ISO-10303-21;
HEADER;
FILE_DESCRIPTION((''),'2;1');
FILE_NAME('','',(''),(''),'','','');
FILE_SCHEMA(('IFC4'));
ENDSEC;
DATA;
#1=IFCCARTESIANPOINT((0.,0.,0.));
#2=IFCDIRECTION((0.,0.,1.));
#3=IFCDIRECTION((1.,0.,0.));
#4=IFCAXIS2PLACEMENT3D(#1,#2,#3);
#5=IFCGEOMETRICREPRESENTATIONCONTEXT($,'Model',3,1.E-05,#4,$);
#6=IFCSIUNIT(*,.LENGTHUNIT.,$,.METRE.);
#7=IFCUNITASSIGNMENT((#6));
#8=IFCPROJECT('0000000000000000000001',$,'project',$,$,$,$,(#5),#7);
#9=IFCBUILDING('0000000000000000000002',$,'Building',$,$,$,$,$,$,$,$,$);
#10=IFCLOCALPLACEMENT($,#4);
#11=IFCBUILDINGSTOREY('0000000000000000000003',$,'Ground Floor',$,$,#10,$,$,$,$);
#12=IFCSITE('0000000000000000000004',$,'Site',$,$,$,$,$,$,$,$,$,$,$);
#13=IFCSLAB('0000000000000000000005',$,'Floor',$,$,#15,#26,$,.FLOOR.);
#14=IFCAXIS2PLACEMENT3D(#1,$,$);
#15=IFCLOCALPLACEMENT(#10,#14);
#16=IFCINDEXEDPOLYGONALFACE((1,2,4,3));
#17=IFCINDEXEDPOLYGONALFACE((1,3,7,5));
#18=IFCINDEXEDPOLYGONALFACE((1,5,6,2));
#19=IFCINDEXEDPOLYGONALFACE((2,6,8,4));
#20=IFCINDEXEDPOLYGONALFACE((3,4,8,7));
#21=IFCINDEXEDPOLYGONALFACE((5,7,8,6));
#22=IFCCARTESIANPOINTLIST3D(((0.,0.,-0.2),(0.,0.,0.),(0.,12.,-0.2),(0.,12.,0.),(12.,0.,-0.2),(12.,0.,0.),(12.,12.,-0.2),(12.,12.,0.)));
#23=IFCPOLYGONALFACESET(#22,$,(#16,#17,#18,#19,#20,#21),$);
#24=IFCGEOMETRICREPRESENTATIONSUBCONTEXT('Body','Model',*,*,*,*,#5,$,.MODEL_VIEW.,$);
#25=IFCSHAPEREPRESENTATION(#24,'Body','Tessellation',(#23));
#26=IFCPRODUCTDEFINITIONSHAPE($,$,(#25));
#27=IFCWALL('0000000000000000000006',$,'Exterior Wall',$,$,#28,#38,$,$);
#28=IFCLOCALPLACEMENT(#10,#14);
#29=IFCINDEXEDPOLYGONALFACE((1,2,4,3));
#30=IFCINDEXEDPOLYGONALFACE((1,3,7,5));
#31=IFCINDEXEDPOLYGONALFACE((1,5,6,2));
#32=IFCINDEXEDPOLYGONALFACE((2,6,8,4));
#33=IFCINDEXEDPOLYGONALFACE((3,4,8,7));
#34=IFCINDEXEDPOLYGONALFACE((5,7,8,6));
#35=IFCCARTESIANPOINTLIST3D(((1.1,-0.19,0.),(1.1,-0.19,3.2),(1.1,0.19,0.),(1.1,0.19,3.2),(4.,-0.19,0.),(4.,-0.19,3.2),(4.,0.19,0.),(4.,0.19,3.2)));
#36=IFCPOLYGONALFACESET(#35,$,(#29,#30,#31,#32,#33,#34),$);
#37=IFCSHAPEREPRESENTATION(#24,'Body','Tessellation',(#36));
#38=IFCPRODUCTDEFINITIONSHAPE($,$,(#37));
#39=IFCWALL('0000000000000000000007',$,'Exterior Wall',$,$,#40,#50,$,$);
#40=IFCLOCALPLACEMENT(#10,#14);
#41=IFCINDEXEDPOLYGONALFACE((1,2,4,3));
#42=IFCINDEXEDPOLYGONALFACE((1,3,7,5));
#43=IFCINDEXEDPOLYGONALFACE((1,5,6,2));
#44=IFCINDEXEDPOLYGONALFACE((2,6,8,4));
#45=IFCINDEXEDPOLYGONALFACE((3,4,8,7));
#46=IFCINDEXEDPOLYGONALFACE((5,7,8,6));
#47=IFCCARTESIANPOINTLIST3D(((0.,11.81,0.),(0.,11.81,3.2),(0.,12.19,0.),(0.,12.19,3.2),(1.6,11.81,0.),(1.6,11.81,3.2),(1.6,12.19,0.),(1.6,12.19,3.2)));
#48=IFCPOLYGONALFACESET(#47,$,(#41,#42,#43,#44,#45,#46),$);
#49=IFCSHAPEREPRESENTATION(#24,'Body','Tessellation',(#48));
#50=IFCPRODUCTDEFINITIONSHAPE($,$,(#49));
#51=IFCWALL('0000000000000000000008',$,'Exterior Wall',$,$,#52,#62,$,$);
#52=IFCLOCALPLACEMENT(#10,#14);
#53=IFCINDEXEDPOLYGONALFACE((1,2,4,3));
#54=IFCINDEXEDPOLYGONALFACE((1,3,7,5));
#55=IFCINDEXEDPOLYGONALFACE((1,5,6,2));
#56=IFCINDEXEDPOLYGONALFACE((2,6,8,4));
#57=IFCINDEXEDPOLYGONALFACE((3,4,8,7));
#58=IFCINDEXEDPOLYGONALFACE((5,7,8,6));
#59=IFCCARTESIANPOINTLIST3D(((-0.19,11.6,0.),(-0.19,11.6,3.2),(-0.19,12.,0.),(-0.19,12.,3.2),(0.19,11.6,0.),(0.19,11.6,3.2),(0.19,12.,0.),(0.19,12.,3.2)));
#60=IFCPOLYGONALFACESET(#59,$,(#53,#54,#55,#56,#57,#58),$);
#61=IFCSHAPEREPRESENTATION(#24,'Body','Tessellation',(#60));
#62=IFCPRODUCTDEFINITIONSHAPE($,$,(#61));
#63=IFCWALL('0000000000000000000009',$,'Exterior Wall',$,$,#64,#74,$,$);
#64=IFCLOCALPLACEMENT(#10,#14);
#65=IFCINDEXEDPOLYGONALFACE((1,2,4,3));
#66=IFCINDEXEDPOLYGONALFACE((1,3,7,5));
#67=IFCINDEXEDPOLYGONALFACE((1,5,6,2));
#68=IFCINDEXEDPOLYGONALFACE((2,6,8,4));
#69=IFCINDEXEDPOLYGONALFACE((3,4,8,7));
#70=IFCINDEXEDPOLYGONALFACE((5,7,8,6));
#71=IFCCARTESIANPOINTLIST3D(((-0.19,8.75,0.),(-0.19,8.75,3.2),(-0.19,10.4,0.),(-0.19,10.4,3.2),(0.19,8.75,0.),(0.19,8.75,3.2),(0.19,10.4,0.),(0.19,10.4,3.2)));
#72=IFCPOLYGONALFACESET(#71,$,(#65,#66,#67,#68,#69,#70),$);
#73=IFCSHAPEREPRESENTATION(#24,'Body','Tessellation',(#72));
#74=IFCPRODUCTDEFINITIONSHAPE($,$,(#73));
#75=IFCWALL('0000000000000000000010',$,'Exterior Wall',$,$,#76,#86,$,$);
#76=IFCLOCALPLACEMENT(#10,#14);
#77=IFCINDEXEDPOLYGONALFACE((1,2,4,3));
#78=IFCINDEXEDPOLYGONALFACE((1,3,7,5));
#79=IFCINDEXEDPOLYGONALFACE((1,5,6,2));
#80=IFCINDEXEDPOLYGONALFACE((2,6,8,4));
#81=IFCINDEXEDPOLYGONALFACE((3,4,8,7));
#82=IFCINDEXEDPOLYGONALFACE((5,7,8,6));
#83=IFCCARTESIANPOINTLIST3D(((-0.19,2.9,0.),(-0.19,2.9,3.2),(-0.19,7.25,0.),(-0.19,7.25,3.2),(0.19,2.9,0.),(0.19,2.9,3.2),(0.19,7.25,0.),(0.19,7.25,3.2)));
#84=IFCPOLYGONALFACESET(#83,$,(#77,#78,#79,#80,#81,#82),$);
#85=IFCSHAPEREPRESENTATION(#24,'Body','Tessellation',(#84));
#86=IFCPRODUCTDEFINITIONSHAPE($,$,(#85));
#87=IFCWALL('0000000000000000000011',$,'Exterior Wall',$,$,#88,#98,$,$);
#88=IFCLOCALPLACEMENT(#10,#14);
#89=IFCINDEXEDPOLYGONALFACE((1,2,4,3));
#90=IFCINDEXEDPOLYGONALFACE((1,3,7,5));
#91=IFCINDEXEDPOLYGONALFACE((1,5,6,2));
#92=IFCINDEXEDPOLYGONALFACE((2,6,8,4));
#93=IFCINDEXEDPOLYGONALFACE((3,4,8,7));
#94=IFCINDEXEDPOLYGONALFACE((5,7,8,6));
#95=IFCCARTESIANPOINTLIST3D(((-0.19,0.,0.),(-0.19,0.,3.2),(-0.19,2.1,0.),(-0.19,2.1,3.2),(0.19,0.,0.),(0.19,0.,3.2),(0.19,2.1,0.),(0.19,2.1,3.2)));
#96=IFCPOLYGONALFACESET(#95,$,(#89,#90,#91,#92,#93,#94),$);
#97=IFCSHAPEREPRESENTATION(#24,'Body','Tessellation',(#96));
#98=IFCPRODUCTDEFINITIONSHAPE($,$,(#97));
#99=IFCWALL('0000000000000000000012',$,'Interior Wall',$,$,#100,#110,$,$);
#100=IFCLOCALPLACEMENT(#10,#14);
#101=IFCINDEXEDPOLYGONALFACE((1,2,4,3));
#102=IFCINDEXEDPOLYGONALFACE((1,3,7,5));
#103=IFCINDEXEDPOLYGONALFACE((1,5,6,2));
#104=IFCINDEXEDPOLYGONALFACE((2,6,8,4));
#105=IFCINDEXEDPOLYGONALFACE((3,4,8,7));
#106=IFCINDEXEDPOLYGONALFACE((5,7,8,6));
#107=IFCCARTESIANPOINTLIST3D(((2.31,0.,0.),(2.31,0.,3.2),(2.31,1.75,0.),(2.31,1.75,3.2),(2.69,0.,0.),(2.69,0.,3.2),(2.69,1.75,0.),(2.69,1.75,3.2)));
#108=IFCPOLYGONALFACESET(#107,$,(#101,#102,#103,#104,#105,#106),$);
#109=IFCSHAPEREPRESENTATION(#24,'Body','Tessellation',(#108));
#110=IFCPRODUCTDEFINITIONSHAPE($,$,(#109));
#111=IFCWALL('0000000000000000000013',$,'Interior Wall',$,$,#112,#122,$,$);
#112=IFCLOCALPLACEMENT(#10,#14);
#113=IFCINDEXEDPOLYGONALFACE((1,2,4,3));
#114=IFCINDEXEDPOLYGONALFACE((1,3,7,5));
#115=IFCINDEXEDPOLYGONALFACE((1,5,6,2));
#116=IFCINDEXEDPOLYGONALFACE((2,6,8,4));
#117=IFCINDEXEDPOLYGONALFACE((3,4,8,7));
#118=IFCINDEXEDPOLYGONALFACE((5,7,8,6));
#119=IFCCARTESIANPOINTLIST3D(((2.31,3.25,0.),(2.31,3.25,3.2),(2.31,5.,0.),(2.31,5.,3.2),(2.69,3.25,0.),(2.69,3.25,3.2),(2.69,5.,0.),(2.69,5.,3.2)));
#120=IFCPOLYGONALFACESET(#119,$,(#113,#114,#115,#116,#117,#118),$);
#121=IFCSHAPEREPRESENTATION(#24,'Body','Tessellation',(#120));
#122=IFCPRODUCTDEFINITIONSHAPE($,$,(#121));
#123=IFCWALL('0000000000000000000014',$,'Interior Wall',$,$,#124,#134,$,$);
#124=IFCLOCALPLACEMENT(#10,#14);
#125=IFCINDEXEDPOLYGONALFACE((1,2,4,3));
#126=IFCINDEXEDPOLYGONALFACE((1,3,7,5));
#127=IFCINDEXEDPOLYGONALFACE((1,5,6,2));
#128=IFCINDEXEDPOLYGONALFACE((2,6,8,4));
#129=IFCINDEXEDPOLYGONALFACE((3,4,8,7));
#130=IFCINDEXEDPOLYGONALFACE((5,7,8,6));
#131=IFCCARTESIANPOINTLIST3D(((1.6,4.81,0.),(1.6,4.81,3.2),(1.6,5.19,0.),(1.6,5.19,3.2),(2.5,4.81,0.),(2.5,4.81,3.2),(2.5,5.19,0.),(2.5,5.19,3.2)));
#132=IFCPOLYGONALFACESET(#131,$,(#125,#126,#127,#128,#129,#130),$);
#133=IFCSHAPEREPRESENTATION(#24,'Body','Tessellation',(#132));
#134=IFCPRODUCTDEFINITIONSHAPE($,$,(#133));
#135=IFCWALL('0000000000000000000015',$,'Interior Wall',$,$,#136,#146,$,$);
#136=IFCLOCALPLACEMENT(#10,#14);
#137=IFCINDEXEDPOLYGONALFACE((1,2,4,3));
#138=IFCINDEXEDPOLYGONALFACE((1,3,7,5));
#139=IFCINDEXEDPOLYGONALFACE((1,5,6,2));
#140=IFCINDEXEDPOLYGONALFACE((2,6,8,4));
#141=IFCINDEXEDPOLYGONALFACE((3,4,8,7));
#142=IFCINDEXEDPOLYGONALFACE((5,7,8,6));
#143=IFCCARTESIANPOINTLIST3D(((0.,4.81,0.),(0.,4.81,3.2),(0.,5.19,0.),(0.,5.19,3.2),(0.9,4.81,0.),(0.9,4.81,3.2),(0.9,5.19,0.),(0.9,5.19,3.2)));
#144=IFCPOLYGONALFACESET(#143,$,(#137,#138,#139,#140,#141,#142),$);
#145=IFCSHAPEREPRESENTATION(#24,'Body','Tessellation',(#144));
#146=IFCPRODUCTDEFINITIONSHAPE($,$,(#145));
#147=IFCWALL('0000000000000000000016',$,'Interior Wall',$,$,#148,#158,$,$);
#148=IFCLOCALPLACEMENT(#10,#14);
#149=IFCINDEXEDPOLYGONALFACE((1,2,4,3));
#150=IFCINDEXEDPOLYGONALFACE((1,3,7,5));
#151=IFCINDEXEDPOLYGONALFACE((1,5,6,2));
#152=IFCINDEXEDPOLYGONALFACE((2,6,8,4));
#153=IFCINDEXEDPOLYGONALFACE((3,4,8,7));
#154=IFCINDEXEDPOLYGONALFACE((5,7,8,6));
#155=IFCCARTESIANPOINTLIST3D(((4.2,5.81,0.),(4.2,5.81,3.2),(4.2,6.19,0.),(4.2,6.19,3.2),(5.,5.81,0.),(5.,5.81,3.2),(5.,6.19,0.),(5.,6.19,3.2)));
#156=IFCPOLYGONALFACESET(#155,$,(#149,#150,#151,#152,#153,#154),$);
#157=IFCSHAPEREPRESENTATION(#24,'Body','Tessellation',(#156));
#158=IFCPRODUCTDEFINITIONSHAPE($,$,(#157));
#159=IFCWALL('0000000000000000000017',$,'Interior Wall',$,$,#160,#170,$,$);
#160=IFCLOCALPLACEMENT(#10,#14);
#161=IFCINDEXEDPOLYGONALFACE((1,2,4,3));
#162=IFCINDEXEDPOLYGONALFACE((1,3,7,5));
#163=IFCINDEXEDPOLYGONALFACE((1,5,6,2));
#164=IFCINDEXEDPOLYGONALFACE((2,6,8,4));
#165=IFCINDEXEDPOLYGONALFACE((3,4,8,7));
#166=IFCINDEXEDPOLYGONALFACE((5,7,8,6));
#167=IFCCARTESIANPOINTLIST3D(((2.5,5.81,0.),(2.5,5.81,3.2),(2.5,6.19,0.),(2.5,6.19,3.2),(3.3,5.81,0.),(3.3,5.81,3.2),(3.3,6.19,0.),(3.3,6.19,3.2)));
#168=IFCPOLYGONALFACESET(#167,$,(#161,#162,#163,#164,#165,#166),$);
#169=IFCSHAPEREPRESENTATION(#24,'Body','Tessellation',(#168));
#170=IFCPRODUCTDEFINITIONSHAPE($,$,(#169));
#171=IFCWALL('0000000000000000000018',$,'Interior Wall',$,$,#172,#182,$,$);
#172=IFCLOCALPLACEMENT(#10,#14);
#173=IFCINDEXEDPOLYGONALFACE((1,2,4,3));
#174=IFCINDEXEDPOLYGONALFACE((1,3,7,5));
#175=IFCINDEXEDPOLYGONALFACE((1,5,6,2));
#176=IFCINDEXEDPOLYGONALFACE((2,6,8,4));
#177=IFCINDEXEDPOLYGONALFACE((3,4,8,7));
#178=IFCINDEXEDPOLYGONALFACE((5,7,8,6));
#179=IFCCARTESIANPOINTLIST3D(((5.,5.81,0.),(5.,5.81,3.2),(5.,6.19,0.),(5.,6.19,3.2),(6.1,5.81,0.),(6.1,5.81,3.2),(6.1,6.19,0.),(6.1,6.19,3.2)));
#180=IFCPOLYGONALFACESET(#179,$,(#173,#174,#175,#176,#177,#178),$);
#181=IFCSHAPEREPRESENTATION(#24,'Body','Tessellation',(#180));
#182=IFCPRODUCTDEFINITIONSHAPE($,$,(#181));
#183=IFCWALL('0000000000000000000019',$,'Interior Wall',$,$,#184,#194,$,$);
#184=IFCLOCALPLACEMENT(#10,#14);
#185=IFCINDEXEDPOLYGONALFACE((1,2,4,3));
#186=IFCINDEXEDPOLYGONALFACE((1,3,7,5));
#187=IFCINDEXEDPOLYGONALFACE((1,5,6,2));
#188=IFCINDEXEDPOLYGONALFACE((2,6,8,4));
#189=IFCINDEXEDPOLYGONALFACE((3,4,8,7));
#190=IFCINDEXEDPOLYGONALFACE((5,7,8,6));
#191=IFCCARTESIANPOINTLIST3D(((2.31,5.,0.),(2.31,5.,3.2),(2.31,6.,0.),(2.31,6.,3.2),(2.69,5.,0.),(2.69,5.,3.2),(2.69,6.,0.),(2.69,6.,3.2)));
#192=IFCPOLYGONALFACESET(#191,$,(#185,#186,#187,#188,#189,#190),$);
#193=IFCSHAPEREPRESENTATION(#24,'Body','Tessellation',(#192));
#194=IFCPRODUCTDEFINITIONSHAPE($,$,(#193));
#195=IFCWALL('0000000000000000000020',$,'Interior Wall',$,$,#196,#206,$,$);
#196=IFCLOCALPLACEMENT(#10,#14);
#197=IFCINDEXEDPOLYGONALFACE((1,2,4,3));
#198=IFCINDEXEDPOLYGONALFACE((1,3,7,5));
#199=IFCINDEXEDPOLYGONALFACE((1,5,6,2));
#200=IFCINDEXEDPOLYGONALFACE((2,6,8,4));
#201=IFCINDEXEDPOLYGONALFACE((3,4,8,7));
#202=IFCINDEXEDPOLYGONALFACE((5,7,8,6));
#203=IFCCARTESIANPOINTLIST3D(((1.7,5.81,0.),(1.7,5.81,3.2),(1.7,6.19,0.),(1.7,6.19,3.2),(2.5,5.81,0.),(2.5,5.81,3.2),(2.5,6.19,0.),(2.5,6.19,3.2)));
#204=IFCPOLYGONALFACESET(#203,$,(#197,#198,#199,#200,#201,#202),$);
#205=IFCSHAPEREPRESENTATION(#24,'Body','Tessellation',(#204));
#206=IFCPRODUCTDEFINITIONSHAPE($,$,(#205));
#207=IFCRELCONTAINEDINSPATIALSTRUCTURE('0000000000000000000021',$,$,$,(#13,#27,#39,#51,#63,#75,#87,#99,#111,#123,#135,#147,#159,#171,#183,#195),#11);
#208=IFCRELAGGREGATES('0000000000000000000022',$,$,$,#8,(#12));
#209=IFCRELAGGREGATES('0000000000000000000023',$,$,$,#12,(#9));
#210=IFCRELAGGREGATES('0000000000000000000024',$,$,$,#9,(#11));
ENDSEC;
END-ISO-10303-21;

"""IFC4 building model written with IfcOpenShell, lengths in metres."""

from ifc_helpers import new_model, si_unit, frame, origin_with_axes, place, context, subcontext, project, spatial, indexed_curve, outline, extrude, element, save


model = new_model("IFC4")

# Units and contexts
model_context = context("Model", 3, precision=1e-05, world=origin_with_axes())
body_context = subcontext(model_context, "Body", "Model", "MODEL_VIEW")
ifc_project = project(units=[si_unit("LENGTHUNIT", "METRE")], contexts=[model_context])

# Site, building, storey
site = spatial("IfcSite", under=ifc_project, Name="Site")
building = spatial("IfcBuilding", under=site, Name="Building")
storey_placement = place(None, origin_with_axes())
storey = spatial("IfcBuildingStorey", under=building, at=storey_placement, Name="Ground Floor")

# Slab
slab_placement = place(storey_placement, frame((0.0, 0.0, -0.2), z_axis=(0.0, 0.0, 1.0), x_axis=(1.0, 0.0, 0.0)))
element("IfcSlab", 1, at=slab_placement, inside=storey, Name="Floor", PredefinedType="FLOOR", context=body_context, shape_type="SweptSolid", body=[
    extrude(outline(indexed_curve([(0.0, 0.0), (12.0, 0.0), (12.0, 12.0), (0.0, 12.0)])), None, (0.0, 0.0, 1.0), 0.2),
])

# Walls
wall_1_placement = place(storey_placement, frame((1.1, 0.0, 0.0), z_axis=(0.0, 0.0, 1.0), x_axis=(1.0, 0.0, 0.0)))
element("IfcWall", 2, at=wall_1_placement, inside=storey, Name="Exterior Wall", context=body_context, shape_type="SweptSolid", body=[
    extrude(outline(indexed_curve([(0.0, 0.0), (0.0, 0.38), (2.9, 0.38), (2.9, 0.0), (0.0, 0.0)], self_intersect=False)), frame((0.0, -0.19, 0.0), z_axis=(0.0, 0.0, 1.0), x_axis=(1.0, 0.0, 0.0)), (0.0, 0.0, 1.0), 3.2),
])
wall_2_placement = place(storey_placement, frame((1.6, 12.0, 0.0), z_axis=(0.0, 0.0, 1.0), x_axis=(-1.0, 0.0, 0.0)))
element("IfcWall", 3, at=wall_2_placement, inside=storey, Name="Exterior Wall", context=body_context, shape_type="SweptSolid", body=[
    extrude(outline(indexed_curve([(0.0, 0.0), (0.0, 0.38), (1.6, 0.38), (1.6, 0.0), (0.0, 0.0)], self_intersect=False)), frame((0.0, -0.19, 0.0), z_axis=(0.0, 0.0, 1.0), x_axis=(1.0, 0.0, 0.0)), (0.0, 0.0, 1.0), 3.2),
])
wall_3_placement = place(storey_placement, frame((0.0, 12.0, 0.0), z_axis=(0.0, 0.0, 1.0), x_axis=(0.0, -1.0, 0.0)))
element("IfcWall", 4, at=wall_3_placement, inside=storey, Name="Exterior Wall", context=body_context, shape_type="SweptSolid", body=[
    extrude(outline(indexed_curve([(0.0, 0.0), (0.0, 0.38), (0.4, 0.38), (0.4, 0.0), (0.0, 0.0)], self_intersect=False)), frame((0.0, -0.19, 0.0), z_axis=(0.0, 0.0, 1.0), x_axis=(1.0, 0.0, 0.0)), (0.0, 0.0, 1.0), 3.2),
])
wall_4_placement = place(storey_placement, frame((0.0, 10.4, 0.0), z_axis=(0.0, 0.0, 1.0), x_axis=(0.0, -1.0, 0.0)))
element("IfcWall", 5, at=wall_4_placement, inside=storey, Name="Exterior Wall", context=body_context, shape_type="SweptSolid", body=[
    extrude(outline(indexed_curve([(0.0, 0.0), (0.0, 0.38), (1.65, 0.38), (1.65, 0.0), (0.0, 0.0)], self_intersect=False)), frame((0.0, -0.19, 0.0), z_axis=(0.0, 0.0, 1.0), x_axis=(1.0, 0.0, 0.0)), (0.0, 0.0, 1.0), 3.2),
])
wall_5_placement = place(storey_placement, frame((0.0, 7.25, 0.0), z_axis=(0.0, 0.0, 1.0), x_axis=(0.0, -1.0, 0.0)))
element("IfcWall", 6, at=wall_5_placement, inside=storey, Name="Exterior Wall", context=body_context, shape_type="SweptSolid", body=[
    extrude(outline(indexed_curve([(0.0, 0.0), (0.0, 0.38), (4.35, 0.38), (4.35, 0.0), (0.0, 0.0)], self_intersect=False)), frame((0.0, -0.19, 0.0), z_axis=(0.0, 0.0, 1.0), x_axis=(1.0, 0.0, 0.0)), (0.0, 0.0, 1.0), 3.2),
])
wall_6_placement = place(storey_placement, frame((0.0, 2.1, 0.0), z_axis=(0.0, 0.0, 1.0), x_axis=(0.0, -1.0, 0.0)))
element("IfcWall", 7, at=wall_6_placement, inside=storey, Name="Exterior Wall", context=body_context, shape_type="SweptSolid", body=[
    extrude(outline(indexed_curve([(0.0, 0.0), (0.0, 0.38), (2.1, 0.38), (2.1, 0.0), (0.0, 0.0)], self_intersect=False)), frame((0.0, -0.19, 0.0), z_axis=(0.0, 0.0, 1.0), x_axis=(1.0, 0.0, 0.0)), (0.0, 0.0, 1.0), 3.2),
])
for number, where, z_axis, x_axis, name in (
    (8, (2.5, 0.0, 0.0), (0.0, 0.0, 1.0), (0.0, 1.0, 0.0), "Interior Wall"),
    (9, (2.5, 3.25, 0.0), (0.0, 0.0, 1.0), (0.0, 1.0, 0.0), "Interior Wall"),
):
    element("IfcWall", number, at=place(storey_placement, frame(where, z_axis=z_axis, x_axis=x_axis)), inside=storey, Name=name, context=body_context, shape_type="SweptSolid", body=[
        extrude(outline(indexed_curve([(0.0, 0.0), (0.0, 0.38), (1.75, 0.38), (1.75, 0.0), (0.0, 0.0)], self_intersect=False)), frame((0.0, -0.19, 0.0), z_axis=(0.0, 0.0, 1.0), x_axis=(1.0, 0.0, 0.0)), (0.0, 0.0, 1.0), 3.2),
    ])
for number, where, z_axis, x_axis, name in (
    (10, (2.5, 5.0, 0.0), (0.0, 0.0, 1.0), (-1.0, 0.0, 0.0), "Interior Wall"),
    (11, (0.9, 5.0, 0.0), (0.0, 0.0, 1.0), (-1.0, 0.0, 0.0), "Interior Wall"),
):
    element("IfcWall", number, at=place(storey_placement, frame(where, z_axis=z_axis, x_axis=x_axis)), inside=storey, Name=name, context=body_context, shape_type="SweptSolid", body=[
        extrude(outline(indexed_curve([(0.0, 0.0), (0.0, 0.38), (0.9, 0.38), (0.9, 0.0), (0.0, 0.0)], self_intersect=False)), frame((0.0, -0.19, 0.0), z_axis=(0.0, 0.0, 1.0), x_axis=(1.0, 0.0, 0.0)), (0.0, 0.0, 1.0), 3.2),
    ])
for number, where, z_axis, x_axis, name in (
    (12, (5.0, 6.0, 0.0), (0.0, 0.0, 1.0), (-1.0, 0.0, 0.0), "Interior Wall"),
    (13, (3.3, 6.0, 0.0), (0.0, 0.0, 1.0), (-1.0, 0.0, 0.0), "Interior Wall"),
):
    element("IfcWall", number, at=place(storey_placement, frame(where, z_axis=z_axis, x_axis=x_axis)), inside=storey, Name=name, context=body_context, shape_type="SweptSolid", body=[
        extrude(outline(indexed_curve([(0.0, 0.0), (0.0, 0.38), (0.8, 0.38), (0.8, 0.0), (0.0, 0.0)], self_intersect=False)), frame((0.0, -0.19, 0.0), z_axis=(0.0, 0.0, 1.0), x_axis=(1.0, 0.0, 0.0)), (0.0, 0.0, 1.0), 3.2),
    ])
wall_7_placement = place(storey_placement, frame((6.1, 6.0, 0.0), z_axis=(0.0, 0.0, 1.0), x_axis=(-1.0, 0.0, 0.0)))
element("IfcWall", 14, at=wall_7_placement, inside=storey, Name="Interior Wall", context=body_context, shape_type="SweptSolid", body=[
    extrude(outline(indexed_curve([(0.0, 0.0), (0.0, 0.38), (1.1, 0.38), (1.1, 0.0), (0.0, 0.0)], self_intersect=False)), frame((0.0, -0.19, 0.0), z_axis=(0.0, 0.0, 1.0), x_axis=(1.0, 0.0, 0.0)), (0.0, 0.0, 1.0), 3.2),
])
wall_8_placement = place(storey_placement, frame((2.5, 6.0, 0.0), z_axis=(0.0, 0.0, 1.0), x_axis=(0.0, -1.0, 0.0)))
element("IfcWall", 15, at=wall_8_placement, inside=storey, Name="Interior Wall", context=body_context, shape_type="SweptSolid", body=[
    extrude(outline(indexed_curve([(0.0, 0.0), (0.0, 0.38), (1.0, 0.38), (1.0, 0.0), (0.0, 0.0)], self_intersect=False)), frame((0.0, -0.19, 0.0), z_axis=(0.0, 0.0, 1.0), x_axis=(1.0, 0.0, 0.0)), (0.0, 0.0, 1.0), 3.2),
])
for number, where, z_axis, x_axis, name in (
    (16, (2.5, 6.0, 0.0), (0.0, 0.0, 1.0), (-1.0, 0.0, 0.0), "Interior Wall"),
):
    element("IfcWall", number, at=place(storey_placement, frame(where, z_axis=z_axis, x_axis=x_axis)), inside=storey, Name=name, context=body_context, shape_type="SweptSolid", body=[
        extrude(outline(indexed_curve([(0.0, 0.0), (0.0, 0.38), (0.8, 0.38), (0.8, 0.0), (0.0, 0.0)], self_intersect=False)), frame((0.0, -0.19, 0.0), z_axis=(0.0, 0.0, 1.0), x_axis=(1.0, 0.0, 0.0)), (0.0, 0.0, 1.0), 3.2),
    ])

save(model, "model.ifc")
